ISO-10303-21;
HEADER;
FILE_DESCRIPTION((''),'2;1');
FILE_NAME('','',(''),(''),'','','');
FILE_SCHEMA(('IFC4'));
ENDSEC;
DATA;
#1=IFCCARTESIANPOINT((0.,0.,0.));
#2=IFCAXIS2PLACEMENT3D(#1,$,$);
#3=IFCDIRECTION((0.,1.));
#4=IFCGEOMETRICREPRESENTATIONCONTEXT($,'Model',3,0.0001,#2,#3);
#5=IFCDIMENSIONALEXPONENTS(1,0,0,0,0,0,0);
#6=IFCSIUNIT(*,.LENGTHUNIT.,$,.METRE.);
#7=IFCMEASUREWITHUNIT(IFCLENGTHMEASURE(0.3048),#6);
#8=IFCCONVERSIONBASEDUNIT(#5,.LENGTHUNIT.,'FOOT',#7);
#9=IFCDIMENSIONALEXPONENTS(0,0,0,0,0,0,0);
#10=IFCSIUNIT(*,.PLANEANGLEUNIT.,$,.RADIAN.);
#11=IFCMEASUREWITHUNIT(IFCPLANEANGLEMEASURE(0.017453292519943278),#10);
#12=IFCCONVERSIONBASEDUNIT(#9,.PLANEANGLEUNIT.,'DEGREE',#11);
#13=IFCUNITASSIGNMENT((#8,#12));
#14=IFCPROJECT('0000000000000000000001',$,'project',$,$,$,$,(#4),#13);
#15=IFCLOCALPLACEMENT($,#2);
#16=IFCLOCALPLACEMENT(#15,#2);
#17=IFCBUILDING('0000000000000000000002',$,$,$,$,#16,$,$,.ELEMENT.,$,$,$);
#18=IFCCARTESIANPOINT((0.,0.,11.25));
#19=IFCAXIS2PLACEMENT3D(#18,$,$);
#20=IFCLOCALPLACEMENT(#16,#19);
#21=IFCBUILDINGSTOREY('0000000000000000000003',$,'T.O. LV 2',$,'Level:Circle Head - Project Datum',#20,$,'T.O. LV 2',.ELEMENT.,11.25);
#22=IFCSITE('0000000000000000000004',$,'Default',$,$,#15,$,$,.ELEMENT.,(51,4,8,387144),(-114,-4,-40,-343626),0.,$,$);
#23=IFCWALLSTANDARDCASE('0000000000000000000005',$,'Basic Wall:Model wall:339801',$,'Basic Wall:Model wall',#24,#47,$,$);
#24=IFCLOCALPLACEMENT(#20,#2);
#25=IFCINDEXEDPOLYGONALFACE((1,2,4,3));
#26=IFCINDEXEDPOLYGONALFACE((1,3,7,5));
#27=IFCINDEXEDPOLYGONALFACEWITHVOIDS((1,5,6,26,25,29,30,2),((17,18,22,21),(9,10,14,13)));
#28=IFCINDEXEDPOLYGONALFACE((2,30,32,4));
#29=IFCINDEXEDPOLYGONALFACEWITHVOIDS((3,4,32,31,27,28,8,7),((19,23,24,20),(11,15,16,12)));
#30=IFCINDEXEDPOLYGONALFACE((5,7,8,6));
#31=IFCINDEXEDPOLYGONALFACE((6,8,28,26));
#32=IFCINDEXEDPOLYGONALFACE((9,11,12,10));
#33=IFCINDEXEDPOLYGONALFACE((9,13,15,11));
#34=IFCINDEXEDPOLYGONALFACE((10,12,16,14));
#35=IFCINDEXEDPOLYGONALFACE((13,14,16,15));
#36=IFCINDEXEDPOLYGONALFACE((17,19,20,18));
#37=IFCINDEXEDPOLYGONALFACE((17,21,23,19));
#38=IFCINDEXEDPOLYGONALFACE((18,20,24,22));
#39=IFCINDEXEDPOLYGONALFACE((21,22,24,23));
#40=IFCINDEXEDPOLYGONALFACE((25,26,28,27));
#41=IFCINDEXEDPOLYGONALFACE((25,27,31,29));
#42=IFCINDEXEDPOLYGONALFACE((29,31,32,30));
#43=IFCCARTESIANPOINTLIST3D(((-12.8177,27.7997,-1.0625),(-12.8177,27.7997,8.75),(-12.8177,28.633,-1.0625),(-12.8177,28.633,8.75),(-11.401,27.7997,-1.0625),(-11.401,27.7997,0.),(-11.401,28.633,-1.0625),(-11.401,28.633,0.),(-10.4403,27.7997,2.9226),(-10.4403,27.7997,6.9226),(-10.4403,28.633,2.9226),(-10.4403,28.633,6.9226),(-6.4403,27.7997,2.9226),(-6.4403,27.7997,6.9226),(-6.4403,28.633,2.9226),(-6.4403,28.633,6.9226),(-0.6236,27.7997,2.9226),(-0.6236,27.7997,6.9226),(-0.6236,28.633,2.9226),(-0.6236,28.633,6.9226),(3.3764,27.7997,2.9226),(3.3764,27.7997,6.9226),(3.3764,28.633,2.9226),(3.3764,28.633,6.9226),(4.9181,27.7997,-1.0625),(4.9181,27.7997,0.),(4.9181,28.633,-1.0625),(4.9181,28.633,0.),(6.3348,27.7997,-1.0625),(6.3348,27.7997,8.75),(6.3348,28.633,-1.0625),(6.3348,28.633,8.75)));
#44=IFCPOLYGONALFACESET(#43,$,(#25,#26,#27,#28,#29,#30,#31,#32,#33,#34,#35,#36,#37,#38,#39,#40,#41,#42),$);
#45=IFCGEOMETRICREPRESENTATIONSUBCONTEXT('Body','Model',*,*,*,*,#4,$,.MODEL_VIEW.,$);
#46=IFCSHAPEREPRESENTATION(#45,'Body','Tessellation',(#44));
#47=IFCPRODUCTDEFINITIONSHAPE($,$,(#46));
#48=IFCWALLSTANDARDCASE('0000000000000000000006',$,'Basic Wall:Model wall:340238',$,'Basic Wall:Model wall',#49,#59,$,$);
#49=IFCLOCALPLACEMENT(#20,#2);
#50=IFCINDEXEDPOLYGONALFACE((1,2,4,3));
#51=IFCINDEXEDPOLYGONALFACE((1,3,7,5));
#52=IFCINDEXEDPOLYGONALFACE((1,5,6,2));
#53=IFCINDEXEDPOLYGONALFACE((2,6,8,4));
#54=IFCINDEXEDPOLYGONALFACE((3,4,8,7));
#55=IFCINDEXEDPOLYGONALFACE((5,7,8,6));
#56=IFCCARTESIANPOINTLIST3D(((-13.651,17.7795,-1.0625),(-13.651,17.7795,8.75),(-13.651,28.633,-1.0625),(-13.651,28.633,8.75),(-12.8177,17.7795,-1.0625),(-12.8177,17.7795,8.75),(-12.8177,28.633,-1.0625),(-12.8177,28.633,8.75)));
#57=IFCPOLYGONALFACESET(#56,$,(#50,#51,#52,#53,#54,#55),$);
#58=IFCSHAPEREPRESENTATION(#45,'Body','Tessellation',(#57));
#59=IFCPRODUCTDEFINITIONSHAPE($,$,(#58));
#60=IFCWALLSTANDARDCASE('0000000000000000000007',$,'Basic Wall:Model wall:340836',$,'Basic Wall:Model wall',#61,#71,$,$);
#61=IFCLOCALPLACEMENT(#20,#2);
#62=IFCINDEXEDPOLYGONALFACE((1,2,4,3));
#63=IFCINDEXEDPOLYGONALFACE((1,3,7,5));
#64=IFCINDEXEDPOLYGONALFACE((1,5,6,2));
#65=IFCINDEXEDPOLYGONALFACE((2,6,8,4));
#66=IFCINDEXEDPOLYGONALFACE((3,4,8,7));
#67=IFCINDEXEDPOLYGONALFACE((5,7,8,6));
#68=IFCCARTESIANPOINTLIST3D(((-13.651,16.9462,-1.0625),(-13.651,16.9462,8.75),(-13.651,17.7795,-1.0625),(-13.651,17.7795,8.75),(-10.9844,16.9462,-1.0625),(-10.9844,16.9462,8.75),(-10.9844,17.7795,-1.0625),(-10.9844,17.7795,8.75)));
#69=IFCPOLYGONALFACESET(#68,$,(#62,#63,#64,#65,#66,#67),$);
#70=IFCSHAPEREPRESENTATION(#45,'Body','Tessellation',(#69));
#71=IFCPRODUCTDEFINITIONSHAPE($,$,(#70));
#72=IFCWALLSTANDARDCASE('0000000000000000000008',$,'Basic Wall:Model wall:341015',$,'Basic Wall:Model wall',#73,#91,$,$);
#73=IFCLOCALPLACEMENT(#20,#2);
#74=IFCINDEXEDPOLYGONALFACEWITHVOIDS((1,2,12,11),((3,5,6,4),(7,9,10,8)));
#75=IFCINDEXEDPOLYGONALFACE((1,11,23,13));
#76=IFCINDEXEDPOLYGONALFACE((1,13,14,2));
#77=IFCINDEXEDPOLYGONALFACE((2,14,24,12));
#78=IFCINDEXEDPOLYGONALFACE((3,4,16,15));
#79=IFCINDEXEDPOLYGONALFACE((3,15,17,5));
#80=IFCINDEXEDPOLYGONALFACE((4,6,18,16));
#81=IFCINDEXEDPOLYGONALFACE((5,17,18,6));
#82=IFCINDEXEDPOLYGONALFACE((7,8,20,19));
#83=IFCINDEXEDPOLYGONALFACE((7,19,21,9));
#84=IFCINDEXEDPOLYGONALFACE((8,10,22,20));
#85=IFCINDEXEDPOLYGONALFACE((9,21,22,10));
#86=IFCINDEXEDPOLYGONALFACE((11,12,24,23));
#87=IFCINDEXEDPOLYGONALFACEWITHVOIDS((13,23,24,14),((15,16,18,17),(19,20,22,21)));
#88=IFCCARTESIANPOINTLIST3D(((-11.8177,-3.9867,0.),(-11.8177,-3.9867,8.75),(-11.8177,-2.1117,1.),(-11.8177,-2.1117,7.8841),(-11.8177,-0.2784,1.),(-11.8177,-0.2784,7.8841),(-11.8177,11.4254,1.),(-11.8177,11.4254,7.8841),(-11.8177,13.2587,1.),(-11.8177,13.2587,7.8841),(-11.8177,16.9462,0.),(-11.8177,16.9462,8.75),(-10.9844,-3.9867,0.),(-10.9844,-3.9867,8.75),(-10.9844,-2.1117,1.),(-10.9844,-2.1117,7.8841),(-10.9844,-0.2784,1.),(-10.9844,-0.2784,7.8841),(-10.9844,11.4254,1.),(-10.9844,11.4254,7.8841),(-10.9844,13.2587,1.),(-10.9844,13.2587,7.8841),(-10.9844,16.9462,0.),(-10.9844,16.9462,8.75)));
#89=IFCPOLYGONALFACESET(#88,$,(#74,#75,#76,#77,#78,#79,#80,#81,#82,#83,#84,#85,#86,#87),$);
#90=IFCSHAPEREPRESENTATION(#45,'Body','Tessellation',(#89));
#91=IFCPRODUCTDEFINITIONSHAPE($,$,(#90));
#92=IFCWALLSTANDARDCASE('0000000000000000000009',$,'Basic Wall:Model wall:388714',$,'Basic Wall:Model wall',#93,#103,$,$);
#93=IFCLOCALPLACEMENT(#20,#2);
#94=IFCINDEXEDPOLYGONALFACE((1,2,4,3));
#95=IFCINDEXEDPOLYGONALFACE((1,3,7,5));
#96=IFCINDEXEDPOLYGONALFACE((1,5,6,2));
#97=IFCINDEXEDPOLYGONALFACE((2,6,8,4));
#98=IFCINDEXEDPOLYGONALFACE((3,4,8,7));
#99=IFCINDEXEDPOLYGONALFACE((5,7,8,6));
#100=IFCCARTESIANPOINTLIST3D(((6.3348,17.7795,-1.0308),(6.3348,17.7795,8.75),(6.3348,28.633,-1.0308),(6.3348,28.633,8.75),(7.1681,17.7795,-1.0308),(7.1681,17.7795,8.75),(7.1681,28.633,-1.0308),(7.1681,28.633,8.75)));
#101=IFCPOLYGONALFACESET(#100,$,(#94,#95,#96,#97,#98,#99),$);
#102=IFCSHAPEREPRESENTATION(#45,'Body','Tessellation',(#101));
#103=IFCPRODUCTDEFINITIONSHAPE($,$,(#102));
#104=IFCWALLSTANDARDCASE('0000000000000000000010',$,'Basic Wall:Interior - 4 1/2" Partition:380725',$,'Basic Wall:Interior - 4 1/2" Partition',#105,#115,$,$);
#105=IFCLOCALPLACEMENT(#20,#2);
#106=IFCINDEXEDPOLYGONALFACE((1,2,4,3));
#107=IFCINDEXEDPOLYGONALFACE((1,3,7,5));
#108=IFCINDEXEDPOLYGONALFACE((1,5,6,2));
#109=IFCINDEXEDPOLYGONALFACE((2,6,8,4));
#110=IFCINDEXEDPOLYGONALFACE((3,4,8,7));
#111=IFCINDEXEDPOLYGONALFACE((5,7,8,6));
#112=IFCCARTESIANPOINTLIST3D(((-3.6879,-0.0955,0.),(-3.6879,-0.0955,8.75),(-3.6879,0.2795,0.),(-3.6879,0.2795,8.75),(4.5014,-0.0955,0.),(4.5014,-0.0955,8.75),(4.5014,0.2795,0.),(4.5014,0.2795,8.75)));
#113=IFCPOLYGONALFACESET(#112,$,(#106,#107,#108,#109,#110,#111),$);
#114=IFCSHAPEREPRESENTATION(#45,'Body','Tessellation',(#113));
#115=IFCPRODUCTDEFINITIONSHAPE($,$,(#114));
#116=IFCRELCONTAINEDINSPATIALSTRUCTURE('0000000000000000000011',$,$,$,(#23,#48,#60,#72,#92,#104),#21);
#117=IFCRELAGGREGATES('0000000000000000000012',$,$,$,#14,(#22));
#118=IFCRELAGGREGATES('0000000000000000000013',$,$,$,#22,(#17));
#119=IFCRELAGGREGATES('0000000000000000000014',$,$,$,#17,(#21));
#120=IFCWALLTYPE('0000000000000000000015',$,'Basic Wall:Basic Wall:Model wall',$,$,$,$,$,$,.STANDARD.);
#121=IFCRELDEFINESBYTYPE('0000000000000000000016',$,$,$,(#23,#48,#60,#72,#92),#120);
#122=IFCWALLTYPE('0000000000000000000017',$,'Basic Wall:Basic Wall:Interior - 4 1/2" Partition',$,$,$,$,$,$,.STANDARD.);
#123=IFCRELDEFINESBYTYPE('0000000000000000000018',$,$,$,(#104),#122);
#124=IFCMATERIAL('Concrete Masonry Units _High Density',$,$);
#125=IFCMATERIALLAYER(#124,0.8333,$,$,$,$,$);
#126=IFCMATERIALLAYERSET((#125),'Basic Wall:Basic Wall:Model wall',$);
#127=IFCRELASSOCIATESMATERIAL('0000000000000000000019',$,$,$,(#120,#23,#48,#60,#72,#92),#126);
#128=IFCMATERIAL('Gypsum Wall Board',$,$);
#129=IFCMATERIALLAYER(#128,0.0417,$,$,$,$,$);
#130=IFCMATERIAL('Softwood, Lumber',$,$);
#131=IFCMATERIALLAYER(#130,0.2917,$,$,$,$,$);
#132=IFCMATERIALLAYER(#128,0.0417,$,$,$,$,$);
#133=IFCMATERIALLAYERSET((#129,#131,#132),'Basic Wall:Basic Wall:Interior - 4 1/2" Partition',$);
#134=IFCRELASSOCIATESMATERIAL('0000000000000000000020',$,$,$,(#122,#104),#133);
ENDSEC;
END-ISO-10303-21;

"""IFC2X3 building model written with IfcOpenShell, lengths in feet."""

from ifc_helpers import new_model, entity, si_unit, converted_unit, direction, frame, frame_2d, origin, origin_2d_with_axis, place, context, subcontext, project, spatial, rectangle, extrude, material, layer, layer_set, layer_usage, type_object, element, save


model = new_model("IFC2X3")

# Units and contexts
model_context = context("Model", 3, precision=0.0001, world=origin(), true_north=direction((0.0, 1.0)))
body_context = subcontext(model_context, "Body", "Model", "MODEL_VIEW")
ifc_project = project(units=[converted_unit("LENGTHUNIT", "FOOT", entity("IfcLengthMeasure", 0.3048), si_unit("LENGTHUNIT", "METRE"), dimensions=[1, 0, 0, 0, 0, 0, 0]), converted_unit("PLANEANGLEUNIT", "DEGREE", entity("IfcPlaneAngleMeasure", 0.017453292519943278), si_unit("PLANEANGLEUNIT", "RADIAN"), dimensions=[0, 0, 0, 0, 0, 0, 0])], contexts=[model_context])

# Site, building, storey
site_placement = place(None, origin())
site = spatial("IfcSite", under=ifc_project, at=site_placement, Name="Default", CompositionType="ELEMENT", RefLatitude=(51, 4, 8, 387144), RefLongitude=(-114, -4, -40, -343626), RefElevation=0.0)
building_placement = place(site_placement, origin())
building = spatial("IfcBuilding", under=site, at=building_placement, CompositionType="ELEMENT")
storey_placement = place(building_placement, frame((0.0, 0.0, 11.25)))
storey = spatial("IfcBuildingStorey", under=building, at=storey_placement, Name="T.O. LV 2", ObjectType="Level:Circle Head - Project Datum", LongName="T.O. LV 2", CompositionType="ELEMENT", Elevation=11.25)

# Wall, openings
ifc_material_1 = material(Name="Concrete Masonry Units _High Density")
ifc_layer_1 = layer(ifc_material_1, 0.8333)
ifc_layer_set_1 = layer_set([ifc_layer_1], Name="Basic Wall:Basic Wall:Model wall")
ifc_layer_usage_1 = layer_usage(ifc_layer_set_1, "AXIS2", "NEGATIVE", 0.4167)
wall_type_1 = type_object("IfcWallType", Name="Basic Wall:Basic Wall:Model wall", PredefinedType="STANDARD", material=ifc_layer_set_1)
wall_1_placement = place(storey_placement, frame((-12.8177, 28.2164, -1.0625)))
wall_1 = element("IfcWallStandardCase", 1, at=wall_1_placement, inside=storey, type_object=wall_type_1, material=ifc_layer_usage_1, Name="Basic Wall:Model wall:339801", ObjectType="Basic Wall:Model wall", context=body_context, shape_type="SweptSolid", body=[
    extrude(rectangle(XDim=19.1525, YDim=0.8333, at=frame_2d((9.5762, 0.0), x_axis=(-1.0, 0.0))), origin(), (0.0, 0.0, 1.0), 9.8125),
])
opening_1_placement = place(wall_1_placement, origin())
element("IfcOpeningElement", 2, at=opening_1_placement, cuts=wall_1, ObjectType="Opening", context=body_context, shape_type="SweptSolid", body=[
    extrude(rectangle(XDim=1.0625, YDim=16.3192, at=origin_2d_with_axis()), frame((9.5762, -0.4167, 0.5313), z_axis=(0.0, 1.0, 0.0), x_axis=(0.0, 0.0, -1.0)), (0.0, 0.0, 1.0), 0.8333),
])
opening_2_placement = place(wall_1_placement, frame((12.8177, -28.2164, 1.0625)))
element("IfcOpeningElement", 3, at=opening_2_placement, cuts=wall_1, ObjectType="Opening", context=body_context, shape_type="SweptSolid", body=[
    extrude(rectangle(XDim=4.0, YDim=4.0, at=frame_2d((0.0, 0.0), x_axis=(0.0, 1.0))), frame((-8.4403, 27.7914, 4.9226), z_axis=(0.0, 1.0, 0.0), x_axis=(-1.0, 0.0, 0.0)), (0.0, 0.0, 1.0), 0.85),
])
opening_3_placement = place(wall_1_placement, frame((12.8177, -28.2164, 1.0625)))
element("IfcOpeningElement", 4, at=opening_3_placement, cuts=wall_1, ObjectType="Opening", context=body_context, shape_type="SweptSolid", body=[
    extrude(rectangle(XDim=4.0, YDim=4.0, at=frame_2d((0.0, 0.0), x_axis=(0.0, 1.0))), frame((1.3764, 27.7914, 4.9226), z_axis=(0.0, 1.0, 0.0), x_axis=(-1.0, 0.0, 0.0)), (0.0, 0.0, 1.0), 0.85),
])

# Walls
ifc_layer_usage_2 = layer_usage(ifc_layer_set_1, "AXIS2", "NEGATIVE", 0.4167)
wall_2_placement = place(storey_placement, frame((-13.2344, 28.633, -1.0625), z_axis=(0.0, 0.0, 1.0), x_axis=(0.0, -1.0, 0.0)))
element("IfcWallStandardCase", 5, at=wall_2_placement, inside=storey, type_object=wall_type_1, material=ifc_layer_usage_2, Name="Basic Wall:Model wall:340238", ObjectType="Basic Wall:Model wall", context=body_context, shape_type="SweptSolid", body=[
    extrude(rectangle(XDim=10.8535, YDim=0.8333, at=frame_2d((5.4268, 0.0), x_axis=(-1.0, 0.0))), origin(), (0.0, 0.0, 1.0), 9.8125),
])
ifc_layer_usage_3 = layer_usage(ifc_layer_set_1, "AXIS2", "NEGATIVE", 0.4167)
wall_3_placement = place(storey_placement, frame((-13.651, 17.3629, -1.0625)))
element("IfcWallStandardCase", 6, at=wall_3_placement, inside=storey, type_object=wall_type_1, material=ifc_layer_usage_3, Name="Basic Wall:Model wall:340836", ObjectType="Basic Wall:Model wall", context=body_context, shape_type="SweptSolid", body=[
    extrude(rectangle(XDim=2.6667, YDim=0.8333, at=frame_2d((1.3333, 0.0), x_axis=(-1.0, 0.0))), origin(), (0.0, 0.0, 1.0), 9.8125),
])

# Wall, openings
ifc_layer_usage_4 = layer_usage(ifc_layer_set_1, "AXIS2", "NEGATIVE", 0.4167)
wall_4_placement = place(storey_placement, frame((-11.401, 16.9462, 0.0), z_axis=(0.0, 0.0, 1.0), x_axis=(0.0, -1.0, 0.0)))
wall_4 = element("IfcWallStandardCase", 7, at=wall_4_placement, inside=storey, type_object=wall_type_1, material=ifc_layer_usage_4, Name="Basic Wall:Model wall:341015", ObjectType="Basic Wall:Model wall", context=body_context, shape_type="SweptSolid", body=[
    extrude(rectangle(XDim=20.9329, YDim=0.8333, at=frame_2d((10.4665, 0.0), x_axis=(-1.0, 0.0))), origin(), (0.0, 0.0, 1.0), 8.75),
])
opening_4_placement = place(wall_4_placement, frame((16.9462, 11.401, 0.0), z_axis=(0.0, 0.0, 1.0), x_axis=(0.0, 1.0, 0.0)))
element("IfcOpeningElement", 8, at=opening_4_placement, cuts=wall_4, ObjectType="Opening", context=body_context, shape_type="SweptSolid", body=[
    extrude(rectangle(XDim=6.8841, YDim=1.8333, at=frame_2d((0.0, 0.0), x_axis=(0.0, 1.0))), frame((-11.826, -1.1951, 4.4421), z_axis=(1.0, 0.0, 0.0), x_axis=(0.0, 1.0, 0.0)), (0.0, 0.0, 1.0), 0.85),
])
opening_5_placement = place(wall_4_placement, frame((16.9462, 11.401, 0.0), z_axis=(0.0, 0.0, 1.0), x_axis=(0.0, 1.0, 0.0)))
element("IfcOpeningElement", 9, at=opening_5_placement, cuts=wall_4, ObjectType="Opening", context=body_context, shape_type="SweptSolid", body=[
    extrude(rectangle(XDim=6.8841, YDim=1.8333, at=frame_2d((0.0, 0.0), x_axis=(0.0, 1.0))), frame((-11.826, 12.342, 4.4421), z_axis=(1.0, 0.0, 0.0), x_axis=(0.0, 1.0, 0.0)), (0.0, 0.0, 1.0), 0.85),
])

# Walls
ifc_layer_usage_5 = layer_usage(ifc_layer_set_1, "AXIS2", "NEGATIVE", 0.4167)
wall_5_placement = place(storey_placement, frame((6.7514, 28.633, -1.0308), z_axis=(0.0, 0.0, 1.0), x_axis=(0.0, -1.0, 0.0)))
element("IfcWallStandardCase", 10, at=wall_5_placement, inside=storey, type_object=wall_type_1, material=ifc_layer_usage_5, Name="Basic Wall:Model wall:388714", ObjectType="Basic Wall:Model wall", context=body_context, shape_type="SweptSolid", body=[
    extrude(rectangle(XDim=10.8535, YDim=0.8333, at=frame_2d((5.4268, 0.0), x_axis=(-1.0, 0.0))), origin(), (0.0, 0.0, 1.0), 9.7808),
])
ifc_material_2 = material(Name="Gypsum Wall Board")
ifc_layer_2 = layer(ifc_material_2, 0.0417)
ifc_material_3 = material(Name="Softwood, Lumber")
ifc_layer_3 = layer(ifc_material_3, 0.2917)
ifc_layer_4 = layer(ifc_material_2, 0.0417)
ifc_layer_set_2 = layer_set([ifc_layer_2, ifc_layer_3, ifc_layer_4], Name="Basic Wall:Basic Wall:Interior - 4 1/2\" Partition")
ifc_layer_usage_6 = layer_usage(ifc_layer_set_2, "AXIS2", "NEGATIVE", 0.1875)
wall_type_2 = type_object("IfcWallType", Name="Basic Wall:Basic Wall:Interior - 4 1/2\" Partition", PredefinedType="STANDARD", material=ifc_layer_set_2)
wall_6_placement = place(storey_placement, frame((-3.6879, 0.092, 0.0)))
element("IfcWallStandardCase", 11, at=wall_6_placement, inside=storey, type_object=wall_type_2, material=ifc_layer_usage_6, Name="Basic Wall:Interior - 4 1/2\" Partition:380725", ObjectType="Basic Wall:Interior - 4 1/2\" Partition", context=body_context, shape_type="SweptSolid", body=[
    extrude(rectangle(XDim=8.1893, YDim=0.375, at=frame_2d((4.0947, 0.0), x_axis=(-1.0, 0.0))), origin(), (0.0, 0.0, 1.0), 8.75),
])

save(model, "model.ifc")
